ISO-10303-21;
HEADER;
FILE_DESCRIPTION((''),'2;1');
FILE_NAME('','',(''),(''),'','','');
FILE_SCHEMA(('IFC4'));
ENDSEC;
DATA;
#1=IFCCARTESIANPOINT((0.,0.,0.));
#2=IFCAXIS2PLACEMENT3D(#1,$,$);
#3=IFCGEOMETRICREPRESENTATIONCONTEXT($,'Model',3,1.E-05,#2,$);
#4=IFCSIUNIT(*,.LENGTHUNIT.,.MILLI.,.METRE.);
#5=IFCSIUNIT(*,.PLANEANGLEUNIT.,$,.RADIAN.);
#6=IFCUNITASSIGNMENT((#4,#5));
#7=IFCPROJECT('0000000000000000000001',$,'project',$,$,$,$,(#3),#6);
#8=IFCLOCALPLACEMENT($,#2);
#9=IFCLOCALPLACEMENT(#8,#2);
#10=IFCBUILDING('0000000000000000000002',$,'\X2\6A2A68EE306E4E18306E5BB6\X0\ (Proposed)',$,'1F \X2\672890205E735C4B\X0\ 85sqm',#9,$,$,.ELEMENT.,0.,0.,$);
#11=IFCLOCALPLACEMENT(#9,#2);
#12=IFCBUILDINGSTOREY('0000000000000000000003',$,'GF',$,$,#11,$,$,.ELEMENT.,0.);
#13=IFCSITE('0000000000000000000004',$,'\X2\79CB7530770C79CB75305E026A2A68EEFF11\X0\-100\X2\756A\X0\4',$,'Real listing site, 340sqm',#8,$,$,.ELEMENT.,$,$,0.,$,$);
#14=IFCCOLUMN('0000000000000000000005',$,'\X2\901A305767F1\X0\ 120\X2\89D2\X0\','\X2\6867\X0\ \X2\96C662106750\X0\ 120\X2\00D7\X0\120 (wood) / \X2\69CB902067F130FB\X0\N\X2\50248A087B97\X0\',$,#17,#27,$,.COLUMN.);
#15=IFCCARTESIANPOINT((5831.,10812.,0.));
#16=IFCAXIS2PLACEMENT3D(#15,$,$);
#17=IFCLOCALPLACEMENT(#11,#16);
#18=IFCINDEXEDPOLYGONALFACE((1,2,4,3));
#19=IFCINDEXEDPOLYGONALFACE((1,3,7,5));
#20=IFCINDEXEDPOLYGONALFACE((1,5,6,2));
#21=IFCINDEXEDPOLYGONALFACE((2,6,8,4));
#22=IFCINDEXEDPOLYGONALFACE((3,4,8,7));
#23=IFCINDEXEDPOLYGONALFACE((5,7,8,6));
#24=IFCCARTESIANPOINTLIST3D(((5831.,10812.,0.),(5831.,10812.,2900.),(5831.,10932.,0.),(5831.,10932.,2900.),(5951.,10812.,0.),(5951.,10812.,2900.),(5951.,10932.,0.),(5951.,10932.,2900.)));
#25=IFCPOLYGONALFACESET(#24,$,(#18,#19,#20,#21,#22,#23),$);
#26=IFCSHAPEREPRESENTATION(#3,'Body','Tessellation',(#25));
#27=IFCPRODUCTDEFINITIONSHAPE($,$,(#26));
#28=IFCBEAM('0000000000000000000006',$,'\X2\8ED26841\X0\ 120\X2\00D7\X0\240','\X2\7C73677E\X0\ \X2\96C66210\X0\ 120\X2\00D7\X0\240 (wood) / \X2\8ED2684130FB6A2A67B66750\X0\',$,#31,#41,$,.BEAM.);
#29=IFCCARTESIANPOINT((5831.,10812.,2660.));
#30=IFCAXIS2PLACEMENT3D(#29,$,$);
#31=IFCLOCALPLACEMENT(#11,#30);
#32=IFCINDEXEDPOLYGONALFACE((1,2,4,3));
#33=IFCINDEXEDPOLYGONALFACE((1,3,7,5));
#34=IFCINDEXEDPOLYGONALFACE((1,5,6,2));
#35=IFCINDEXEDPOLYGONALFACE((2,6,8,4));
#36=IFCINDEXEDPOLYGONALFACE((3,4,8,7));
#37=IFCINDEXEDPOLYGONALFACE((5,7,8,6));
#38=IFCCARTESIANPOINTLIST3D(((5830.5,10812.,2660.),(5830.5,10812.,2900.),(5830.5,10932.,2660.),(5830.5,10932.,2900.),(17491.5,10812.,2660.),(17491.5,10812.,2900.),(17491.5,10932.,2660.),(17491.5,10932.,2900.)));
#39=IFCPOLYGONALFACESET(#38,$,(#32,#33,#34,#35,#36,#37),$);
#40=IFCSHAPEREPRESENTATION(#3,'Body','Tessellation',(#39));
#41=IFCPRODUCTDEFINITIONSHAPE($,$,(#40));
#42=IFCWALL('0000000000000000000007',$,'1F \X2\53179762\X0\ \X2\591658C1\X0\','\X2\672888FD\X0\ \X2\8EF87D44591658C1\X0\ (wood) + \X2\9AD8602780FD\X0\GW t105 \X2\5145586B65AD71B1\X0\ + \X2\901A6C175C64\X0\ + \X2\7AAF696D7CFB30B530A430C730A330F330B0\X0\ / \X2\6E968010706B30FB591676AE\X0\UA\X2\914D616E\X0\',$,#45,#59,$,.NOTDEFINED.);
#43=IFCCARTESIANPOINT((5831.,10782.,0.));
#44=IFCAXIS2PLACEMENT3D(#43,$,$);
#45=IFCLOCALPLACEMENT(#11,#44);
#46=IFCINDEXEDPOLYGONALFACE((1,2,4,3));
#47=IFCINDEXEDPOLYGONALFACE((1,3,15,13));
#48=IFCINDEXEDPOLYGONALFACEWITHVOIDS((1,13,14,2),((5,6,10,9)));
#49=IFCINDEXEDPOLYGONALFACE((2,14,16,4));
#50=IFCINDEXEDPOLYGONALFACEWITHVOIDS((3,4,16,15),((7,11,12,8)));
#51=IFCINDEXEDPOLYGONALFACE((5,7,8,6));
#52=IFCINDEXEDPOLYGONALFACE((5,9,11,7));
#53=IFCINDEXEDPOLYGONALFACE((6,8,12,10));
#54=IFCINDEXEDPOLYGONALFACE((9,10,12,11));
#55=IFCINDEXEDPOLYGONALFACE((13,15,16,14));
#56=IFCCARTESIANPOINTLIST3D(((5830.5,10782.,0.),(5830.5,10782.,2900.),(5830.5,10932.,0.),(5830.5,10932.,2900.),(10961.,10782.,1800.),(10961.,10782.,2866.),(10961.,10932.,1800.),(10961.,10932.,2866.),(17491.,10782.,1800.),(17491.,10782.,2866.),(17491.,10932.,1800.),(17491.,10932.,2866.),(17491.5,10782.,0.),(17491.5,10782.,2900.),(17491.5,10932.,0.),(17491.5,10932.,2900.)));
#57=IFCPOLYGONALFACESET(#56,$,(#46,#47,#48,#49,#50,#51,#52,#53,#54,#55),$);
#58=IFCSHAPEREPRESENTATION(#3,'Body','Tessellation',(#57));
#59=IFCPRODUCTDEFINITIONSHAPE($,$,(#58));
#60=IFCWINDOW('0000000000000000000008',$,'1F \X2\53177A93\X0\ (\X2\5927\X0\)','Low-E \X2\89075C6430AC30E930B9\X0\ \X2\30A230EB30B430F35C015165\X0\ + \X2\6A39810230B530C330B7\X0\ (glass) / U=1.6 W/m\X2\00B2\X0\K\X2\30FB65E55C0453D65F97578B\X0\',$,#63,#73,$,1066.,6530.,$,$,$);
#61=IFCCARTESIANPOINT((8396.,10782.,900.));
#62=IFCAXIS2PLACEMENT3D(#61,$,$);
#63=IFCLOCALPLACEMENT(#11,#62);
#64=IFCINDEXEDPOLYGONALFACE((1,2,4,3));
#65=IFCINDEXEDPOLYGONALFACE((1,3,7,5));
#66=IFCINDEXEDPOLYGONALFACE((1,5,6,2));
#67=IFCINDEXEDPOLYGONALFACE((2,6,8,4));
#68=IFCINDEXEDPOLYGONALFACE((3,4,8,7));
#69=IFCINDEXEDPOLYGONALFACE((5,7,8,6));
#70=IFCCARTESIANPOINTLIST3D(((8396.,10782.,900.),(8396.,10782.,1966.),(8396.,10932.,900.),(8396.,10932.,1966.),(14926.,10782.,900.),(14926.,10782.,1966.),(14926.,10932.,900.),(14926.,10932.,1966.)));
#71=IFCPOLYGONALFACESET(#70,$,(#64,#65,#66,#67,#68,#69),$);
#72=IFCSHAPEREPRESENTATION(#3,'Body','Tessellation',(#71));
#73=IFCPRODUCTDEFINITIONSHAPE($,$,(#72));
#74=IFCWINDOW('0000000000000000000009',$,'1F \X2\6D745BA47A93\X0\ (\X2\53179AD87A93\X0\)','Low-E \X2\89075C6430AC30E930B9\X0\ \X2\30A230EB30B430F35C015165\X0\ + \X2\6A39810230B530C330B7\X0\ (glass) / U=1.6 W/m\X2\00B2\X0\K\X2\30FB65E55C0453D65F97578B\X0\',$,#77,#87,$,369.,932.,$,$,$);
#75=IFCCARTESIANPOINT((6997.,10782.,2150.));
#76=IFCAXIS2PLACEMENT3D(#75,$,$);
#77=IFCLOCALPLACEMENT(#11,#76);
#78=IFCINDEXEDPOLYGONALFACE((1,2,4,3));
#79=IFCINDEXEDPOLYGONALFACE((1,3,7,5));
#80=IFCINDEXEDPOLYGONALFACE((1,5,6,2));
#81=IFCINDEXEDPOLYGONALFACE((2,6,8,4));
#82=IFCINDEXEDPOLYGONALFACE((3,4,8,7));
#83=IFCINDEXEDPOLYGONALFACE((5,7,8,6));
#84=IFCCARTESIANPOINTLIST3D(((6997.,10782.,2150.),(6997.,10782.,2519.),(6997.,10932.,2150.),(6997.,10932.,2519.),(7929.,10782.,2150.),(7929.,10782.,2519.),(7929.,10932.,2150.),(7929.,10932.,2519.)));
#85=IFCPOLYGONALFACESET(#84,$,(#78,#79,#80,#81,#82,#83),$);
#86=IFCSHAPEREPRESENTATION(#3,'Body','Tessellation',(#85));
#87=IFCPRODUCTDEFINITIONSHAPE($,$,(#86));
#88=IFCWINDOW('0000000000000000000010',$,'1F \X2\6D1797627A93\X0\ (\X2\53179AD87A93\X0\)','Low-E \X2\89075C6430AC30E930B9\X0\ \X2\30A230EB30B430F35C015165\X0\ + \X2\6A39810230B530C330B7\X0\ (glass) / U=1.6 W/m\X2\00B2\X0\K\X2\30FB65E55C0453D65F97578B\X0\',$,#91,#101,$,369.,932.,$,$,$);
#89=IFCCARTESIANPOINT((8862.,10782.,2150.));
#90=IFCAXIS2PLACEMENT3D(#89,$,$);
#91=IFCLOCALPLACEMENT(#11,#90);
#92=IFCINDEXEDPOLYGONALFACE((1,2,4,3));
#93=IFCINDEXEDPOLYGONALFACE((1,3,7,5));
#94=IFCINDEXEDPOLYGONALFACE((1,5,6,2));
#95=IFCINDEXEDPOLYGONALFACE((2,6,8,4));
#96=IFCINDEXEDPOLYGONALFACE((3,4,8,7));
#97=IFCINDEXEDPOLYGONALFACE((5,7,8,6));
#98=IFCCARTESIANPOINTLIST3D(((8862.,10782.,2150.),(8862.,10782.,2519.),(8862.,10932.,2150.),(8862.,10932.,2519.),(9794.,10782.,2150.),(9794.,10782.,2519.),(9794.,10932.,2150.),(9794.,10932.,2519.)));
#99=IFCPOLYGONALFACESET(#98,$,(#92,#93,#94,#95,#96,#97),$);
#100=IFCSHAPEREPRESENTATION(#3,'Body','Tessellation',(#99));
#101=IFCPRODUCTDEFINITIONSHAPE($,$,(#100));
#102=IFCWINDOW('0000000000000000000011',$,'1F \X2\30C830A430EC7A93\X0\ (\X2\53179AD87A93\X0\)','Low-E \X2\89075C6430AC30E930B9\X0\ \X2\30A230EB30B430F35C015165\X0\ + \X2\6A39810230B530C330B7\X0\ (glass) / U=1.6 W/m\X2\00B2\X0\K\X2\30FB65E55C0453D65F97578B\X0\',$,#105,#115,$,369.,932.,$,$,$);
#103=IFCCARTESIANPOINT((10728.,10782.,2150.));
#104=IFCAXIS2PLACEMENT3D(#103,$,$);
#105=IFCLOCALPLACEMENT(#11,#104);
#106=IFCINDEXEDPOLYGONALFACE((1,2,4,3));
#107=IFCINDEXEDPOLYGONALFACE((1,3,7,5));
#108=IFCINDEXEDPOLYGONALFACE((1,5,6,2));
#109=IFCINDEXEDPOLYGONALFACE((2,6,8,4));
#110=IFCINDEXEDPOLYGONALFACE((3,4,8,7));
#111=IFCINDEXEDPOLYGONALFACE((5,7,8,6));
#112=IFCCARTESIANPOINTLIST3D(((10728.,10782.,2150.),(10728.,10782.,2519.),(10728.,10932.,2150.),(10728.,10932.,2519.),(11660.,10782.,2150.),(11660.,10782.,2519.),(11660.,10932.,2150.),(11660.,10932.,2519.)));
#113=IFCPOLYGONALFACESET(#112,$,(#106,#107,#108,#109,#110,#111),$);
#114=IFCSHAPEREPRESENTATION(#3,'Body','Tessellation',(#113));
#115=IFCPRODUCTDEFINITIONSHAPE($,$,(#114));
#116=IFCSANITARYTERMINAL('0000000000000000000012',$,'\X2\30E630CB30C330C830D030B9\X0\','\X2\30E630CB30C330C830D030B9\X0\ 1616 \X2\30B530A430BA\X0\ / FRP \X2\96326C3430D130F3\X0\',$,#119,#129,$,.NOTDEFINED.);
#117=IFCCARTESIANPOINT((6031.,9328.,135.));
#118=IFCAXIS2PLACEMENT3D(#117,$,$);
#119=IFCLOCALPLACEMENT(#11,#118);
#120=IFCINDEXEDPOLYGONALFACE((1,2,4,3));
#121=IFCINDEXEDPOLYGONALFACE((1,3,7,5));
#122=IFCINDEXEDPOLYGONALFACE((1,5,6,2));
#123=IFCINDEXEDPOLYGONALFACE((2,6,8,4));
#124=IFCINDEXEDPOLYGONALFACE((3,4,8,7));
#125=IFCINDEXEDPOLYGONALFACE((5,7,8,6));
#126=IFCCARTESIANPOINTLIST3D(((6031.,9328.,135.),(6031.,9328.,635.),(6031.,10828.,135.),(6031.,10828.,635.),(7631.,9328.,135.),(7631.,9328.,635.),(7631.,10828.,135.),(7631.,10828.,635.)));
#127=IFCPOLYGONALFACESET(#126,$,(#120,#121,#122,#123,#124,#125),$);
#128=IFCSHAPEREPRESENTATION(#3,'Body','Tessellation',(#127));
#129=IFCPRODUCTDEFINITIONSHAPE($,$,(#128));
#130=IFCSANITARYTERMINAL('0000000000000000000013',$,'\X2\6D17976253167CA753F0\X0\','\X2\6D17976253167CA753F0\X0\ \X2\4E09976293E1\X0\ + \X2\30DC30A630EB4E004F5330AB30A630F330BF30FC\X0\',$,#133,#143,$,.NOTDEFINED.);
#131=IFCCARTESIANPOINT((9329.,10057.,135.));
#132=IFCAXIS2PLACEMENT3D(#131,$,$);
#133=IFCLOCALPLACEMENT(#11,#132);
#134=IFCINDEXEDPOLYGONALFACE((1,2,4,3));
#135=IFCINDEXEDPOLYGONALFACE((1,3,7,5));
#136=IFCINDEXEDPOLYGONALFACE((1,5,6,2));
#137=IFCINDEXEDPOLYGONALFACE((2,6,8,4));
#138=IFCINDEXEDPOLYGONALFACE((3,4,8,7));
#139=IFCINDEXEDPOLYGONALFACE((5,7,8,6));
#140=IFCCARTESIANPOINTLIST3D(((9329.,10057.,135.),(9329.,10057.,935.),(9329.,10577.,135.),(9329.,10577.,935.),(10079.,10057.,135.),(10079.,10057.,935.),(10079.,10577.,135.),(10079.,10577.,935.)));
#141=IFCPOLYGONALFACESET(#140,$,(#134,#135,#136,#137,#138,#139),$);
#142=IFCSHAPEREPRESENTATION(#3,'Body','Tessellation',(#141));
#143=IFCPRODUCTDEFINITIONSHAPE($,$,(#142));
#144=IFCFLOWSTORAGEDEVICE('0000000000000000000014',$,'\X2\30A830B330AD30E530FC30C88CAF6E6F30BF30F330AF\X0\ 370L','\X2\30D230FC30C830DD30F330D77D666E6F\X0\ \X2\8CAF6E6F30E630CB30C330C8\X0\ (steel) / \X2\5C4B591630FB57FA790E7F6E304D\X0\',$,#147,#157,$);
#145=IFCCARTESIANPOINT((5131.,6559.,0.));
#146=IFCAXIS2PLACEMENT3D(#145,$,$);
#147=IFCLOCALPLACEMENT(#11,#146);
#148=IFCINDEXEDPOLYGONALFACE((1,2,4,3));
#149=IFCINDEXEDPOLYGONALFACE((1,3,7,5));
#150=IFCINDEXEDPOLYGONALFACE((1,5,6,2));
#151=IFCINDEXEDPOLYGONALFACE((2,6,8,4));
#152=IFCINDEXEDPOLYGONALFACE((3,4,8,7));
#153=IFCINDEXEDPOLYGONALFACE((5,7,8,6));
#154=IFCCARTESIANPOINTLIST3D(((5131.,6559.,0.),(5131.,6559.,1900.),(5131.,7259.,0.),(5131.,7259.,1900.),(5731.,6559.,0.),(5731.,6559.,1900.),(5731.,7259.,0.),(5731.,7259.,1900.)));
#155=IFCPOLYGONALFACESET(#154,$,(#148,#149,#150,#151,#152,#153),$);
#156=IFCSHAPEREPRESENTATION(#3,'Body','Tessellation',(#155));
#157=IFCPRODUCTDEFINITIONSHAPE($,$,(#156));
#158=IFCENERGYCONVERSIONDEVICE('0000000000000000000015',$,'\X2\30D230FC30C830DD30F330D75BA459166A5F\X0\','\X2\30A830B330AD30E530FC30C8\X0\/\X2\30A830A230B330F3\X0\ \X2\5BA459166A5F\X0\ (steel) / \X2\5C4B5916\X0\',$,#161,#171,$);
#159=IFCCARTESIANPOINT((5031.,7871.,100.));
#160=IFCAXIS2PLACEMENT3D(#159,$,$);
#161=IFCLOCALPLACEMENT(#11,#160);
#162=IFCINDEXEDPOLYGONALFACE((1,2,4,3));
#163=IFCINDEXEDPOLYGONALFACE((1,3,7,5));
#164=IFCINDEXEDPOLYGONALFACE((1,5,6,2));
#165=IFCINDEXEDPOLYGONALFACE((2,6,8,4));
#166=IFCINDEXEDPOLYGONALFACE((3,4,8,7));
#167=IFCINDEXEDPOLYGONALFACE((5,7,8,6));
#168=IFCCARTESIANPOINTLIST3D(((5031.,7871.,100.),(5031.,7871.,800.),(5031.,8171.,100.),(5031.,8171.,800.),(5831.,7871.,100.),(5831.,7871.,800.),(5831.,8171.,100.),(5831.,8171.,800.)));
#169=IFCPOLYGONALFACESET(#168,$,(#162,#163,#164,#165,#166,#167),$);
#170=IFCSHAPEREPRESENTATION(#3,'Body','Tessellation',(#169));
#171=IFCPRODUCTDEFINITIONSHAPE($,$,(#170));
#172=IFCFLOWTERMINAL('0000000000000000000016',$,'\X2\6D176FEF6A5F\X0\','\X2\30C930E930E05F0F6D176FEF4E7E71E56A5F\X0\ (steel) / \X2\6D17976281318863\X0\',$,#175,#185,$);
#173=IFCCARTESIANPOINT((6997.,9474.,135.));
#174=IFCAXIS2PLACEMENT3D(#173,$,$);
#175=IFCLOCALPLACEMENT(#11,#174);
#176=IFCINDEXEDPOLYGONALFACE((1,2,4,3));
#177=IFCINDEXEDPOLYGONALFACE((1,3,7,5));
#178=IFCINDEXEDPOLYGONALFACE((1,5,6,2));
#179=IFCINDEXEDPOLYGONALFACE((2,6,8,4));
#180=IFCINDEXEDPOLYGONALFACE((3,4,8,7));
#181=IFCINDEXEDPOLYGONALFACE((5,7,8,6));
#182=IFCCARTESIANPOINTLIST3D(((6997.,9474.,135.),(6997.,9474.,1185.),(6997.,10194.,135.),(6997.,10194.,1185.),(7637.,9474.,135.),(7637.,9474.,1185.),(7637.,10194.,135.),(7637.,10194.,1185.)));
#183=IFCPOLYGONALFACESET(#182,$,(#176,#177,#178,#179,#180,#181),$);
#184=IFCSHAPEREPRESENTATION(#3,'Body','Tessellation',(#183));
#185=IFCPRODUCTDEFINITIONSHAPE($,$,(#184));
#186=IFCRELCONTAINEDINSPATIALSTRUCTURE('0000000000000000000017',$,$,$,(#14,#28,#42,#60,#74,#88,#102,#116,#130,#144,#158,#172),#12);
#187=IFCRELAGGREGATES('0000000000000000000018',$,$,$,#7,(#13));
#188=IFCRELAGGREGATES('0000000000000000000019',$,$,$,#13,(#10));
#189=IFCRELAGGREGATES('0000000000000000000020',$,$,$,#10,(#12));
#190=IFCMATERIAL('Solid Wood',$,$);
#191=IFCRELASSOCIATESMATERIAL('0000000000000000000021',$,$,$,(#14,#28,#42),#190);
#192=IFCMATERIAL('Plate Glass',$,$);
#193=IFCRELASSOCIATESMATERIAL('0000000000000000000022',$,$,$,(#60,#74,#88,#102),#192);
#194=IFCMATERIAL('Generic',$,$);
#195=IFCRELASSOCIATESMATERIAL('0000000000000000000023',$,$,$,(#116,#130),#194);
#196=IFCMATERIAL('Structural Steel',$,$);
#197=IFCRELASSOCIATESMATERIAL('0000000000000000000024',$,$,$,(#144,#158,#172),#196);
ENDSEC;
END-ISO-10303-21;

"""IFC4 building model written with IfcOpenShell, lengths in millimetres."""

from ifc_helpers import new_model, si_unit, frame, frame_2d, origin, place, context, project, spatial, rectangle, extrude, material, element, fill, save


model = new_model("IFC4")

# Units and contexts
model_context = context("Model", 3, precision=1e-05, world=origin())
ifc_project = project(units=[si_unit("LENGTHUNIT", "METRE", prefix="MILLI"), si_unit("PLANEANGLEUNIT", "RADIAN")], contexts=[model_context])

# Site, building, storey
site_placement = place(None, origin())
site = spatial("IfcSite", under=ifc_project, at=site_placement, Name="秋田県秋田市横森１-100番4", ObjectType="Real listing site, 340sqm", CompositionType="ELEMENT", RefElevation=0.0)
building_placement = place(site_placement, origin())
building = spatial("IfcBuilding", under=site, at=building_placement, Name="横森の丘の家 (Proposed)", ObjectType="1F 木造平屋 85sqm", CompositionType="ELEMENT", ElevationOfRefHeight=0.0, ElevationOfTerrain=0.0)
storey_placement = place(building_placement, origin())
storey = spatial("IfcBuildingStorey", under=building, at=storey_placement, Name="GF", CompositionType="ELEMENT", Elevation=0.0)

# Column
ifc_material_1 = material(Name="Solid Wood")
column_1_placement = place(storey_placement, frame((5831.0, 10812.0, 0.0)))
element("IfcColumn", 1, at=column_1_placement, inside=storey, material=ifc_material_1, Name="通し柱 120角", Description="桧 集成材 120×120 (wood) / 構造柱・N値計算", PredefinedType="COLUMN", context=model_context, shape_type="SweptSolid", body=[
    extrude(rectangle(XDim=120.0, YDim=120.0, at=frame_2d((60.0, 60.0))), frame((5831.0, 10812.0, 0.0)), (0.0, 0.0, 1.0), 2900.0),
])

# Beam
beam_1_placement = place(storey_placement, frame((5831.0, 10812.0, 2660.0)))
element("IfcBeam", 2, at=beam_1_placement, inside=storey, material=ifc_material_1, Name="軒桁 120×240", Description="米松 集成 120×240 (wood) / 軒桁・横架材", PredefinedType="BEAM", context=model_context, shape_type="SweptSolid", body=[
    extrude(rectangle(XDim=11661.0, YDim=120.0, at=frame_2d((5830.0, 60.0))), frame((5831.0, 10812.0, 2660.0)), (0.0, 0.0, 1.0), 240.0),
])

# Wall, openings, windows
wall_1_placement = place(storey_placement, frame((5831.0, 10782.0, 0.0)))
wall_1 = element("IfcWall", 3, at=wall_1_placement, inside=storey, material=ifc_material_1, Name="1F 北面 外壁", Description="木製 軸組外壁 (wood) + 高性能GW t105 充填断熱 + 通気層 + 窯業系サイディング / 準耐火・外皮UA配慮", PredefinedType="NOTDEFINED", context=model_context, shape_type="SweptSolid", body=[
    extrude(rectangle(XDim=11661.0, YDim=150.0, at=frame_2d((5830.0, 75.0))), frame((5831.0, 10782.0, 0.0)), (0.0, 0.0, 1.0), 2900.0),
])
opening_1_placement = place(storey_placement, frame((8396.0, 10782.0, 900.0)))
opening_1 = element("IfcOpeningElement", 4, at=opening_1_placement, cuts=wall_1, PredefinedType="NOTDEFINED", context=model_context, shape_type="SweptSolid", body=[
    extrude(rectangle(XDim=6530.0, YDim=150.0, at=frame_2d((3265.0, 75.0))), frame((8396.0, 10782.0, 900.0)), (0.0, 0.0, 1.0), 1066.0),
])
opening_2_placement = place(storey_placement, frame((6997.0, 10782.0, 2150.0)))
opening_2 = element("IfcOpeningElement", 5, at=opening_2_placement, cuts=wall_1, PredefinedType="NOTDEFINED", context=model_context, shape_type="SweptSolid", body=[
    extrude(rectangle(XDim=932.0, YDim=150.0, at=frame_2d((466.0, 75.0))), frame((6997.0, 10782.0, 2150.0)), (0.0, 0.0, 1.0), 369.0),
])
opening_3_placement = place(storey_placement, frame((8862.0, 10782.0, 2150.0)))
opening_3 = element("IfcOpeningElement", 6, at=opening_3_placement, cuts=wall_1, PredefinedType="NOTDEFINED", context=model_context, shape_type="SweptSolid", body=[
    extrude(rectangle(XDim=932.0, YDim=150.0, at=frame_2d((466.0, 75.0))), frame((8862.0, 10782.0, 2150.0)), (0.0, 0.0, 1.0), 369.0),
])
opening_4_placement = place(storey_placement, frame((10728.0, 10782.0, 2150.0)))
opening_4 = element("IfcOpeningElement", 7, at=opening_4_placement, cuts=wall_1, PredefinedType="NOTDEFINED", context=model_context, shape_type="SweptSolid", body=[
    extrude(rectangle(XDim=932.0, YDim=150.0, at=frame_2d((466.0, 75.0))), frame((10728.0, 10782.0, 2150.0)), (0.0, 0.0, 1.0), 369.0),
])
ifc_material_2 = material(Name="Plate Glass")
window_1_placement = place(storey_placement, frame((8396.0, 10782.0, 900.0)))
window_1 = element("IfcWindow", 8, at=window_1_placement, inside=storey, material=ifc_material_2, Name="1F 北窓 (大)", Description="Low-E 複層ガラス アルゴン封入 + 樹脂サッシ (glass) / U=1.6 W/m²K・日射取得型", OverallHeight=1066.0, OverallWidth=6530.0, context=model_context, shape_type="SweptSolid", body=[
    extrude(rectangle(XDim=6530.0, YDim=150.0, at=frame_2d((3265.0, 75.0))), frame((8396.0, 10782.0, 900.0)), (0.0, 0.0, 1.0), 1066.0),
])
fill(opening_1, window_1)
window_2_placement = place(storey_placement, frame((6997.0, 10782.0, 2150.0)))
window_2 = element("IfcWindow", 9, at=window_2_placement, inside=storey, material=ifc_material_2, Name="1F 浴室窓 (北高窓)", Description="Low-E 複層ガラス アルゴン封入 + 樹脂サッシ (glass) / U=1.6 W/m²K・日射取得型", OverallHeight=369.0, OverallWidth=932.0, context=model_context, shape_type="SweptSolid", body=[
    extrude(rectangle(XDim=932.0, YDim=150.0, at=frame_2d((466.0, 75.0))), frame((6997.0, 10782.0, 2150.0)), (0.0, 0.0, 1.0), 369.0),
])
fill(opening_2, window_2)
window_3_placement = place(storey_placement, frame((8862.0, 10782.0, 2150.0)))
window_3 = element("IfcWindow", 10, at=window_3_placement, inside=storey, material=ifc_material_2, Name="1F 洗面窓 (北高窓)", Description="Low-E 複層ガラス アルゴン封入 + 樹脂サッシ (glass) / U=1.6 W/m²K・日射取得型", OverallHeight=369.0, OverallWidth=932.0, context=model_context, shape_type="SweptSolid", body=[
    extrude(rectangle(XDim=932.0, YDim=150.0, at=frame_2d((466.0, 75.0))), frame((8862.0, 10782.0, 2150.0)), (0.0, 0.0, 1.0), 369.0),
])
fill(opening_3, window_3)
window_4_placement = place(storey_placement, frame((10728.0, 10782.0, 2150.0)))
window_4 = element("IfcWindow", 11, at=window_4_placement, inside=storey, material=ifc_material_2, Name="1F トイレ窓 (北高窓)", Description="Low-E 複層ガラス アルゴン封入 + 樹脂サッシ (glass) / U=1.6 W/m²K・日射取得型", OverallHeight=369.0, OverallWidth=932.0, context=model_context, shape_type="SweptSolid", body=[
    extrude(rectangle(XDim=932.0, YDim=150.0, at=frame_2d((466.0, 75.0))), frame((10728.0, 10782.0, 2150.0)), (0.0, 0.0, 1.0), 369.0),
])
fill(opening_4, window_4)

# Sanitary terminals
ifc_material_3 = material(Name="Generic")
sanitary_terminal_1_placement = place(storey_placement, frame((6031.0, 9328.0, 135.0)))
element("IfcSanitaryTerminal", 12, at=sanitary_terminal_1_placement, inside=storey, material=ifc_material_3, Name="ユニットバス", Description="ユニットバス 1616 サイズ / FRP 防水パン", PredefinedType="NOTDEFINED", context=model_context, shape_type="SweptSolid", body=[
    extrude(rectangle(XDim=1600.0, YDim=1500.0, at=frame_2d((800.0, 750.0))), frame((6031.0, 9328.0, 135.0)), (0.0, 0.0, 1.0), 500.0),
])
sanitary_terminal_2_placement = place(storey_placement, frame((9329.0, 10057.0, 135.0)))
element("IfcSanitaryTerminal", 13, at=sanitary_terminal_2_placement, inside=storey, material=ifc_material_3, Name="洗面化粧台", Description="洗面化粧台 三面鏡 + ボウル一体カウンター", PredefinedType="NOTDEFINED", context=model_context, shape_type="SweptSolid", body=[
    extrude(rectangle(XDim=750.0, YDim=520.0, at=frame_2d((375.0, 260.0))), frame((9329.0, 10057.0, 135.0)), (0.0, 0.0, 1.0), 800.0),
])

# Flow storage device
ifc_material_4 = material(Name="Structural Steel")
flow_storage_device_placement = place(storey_placement, frame((5131.0, 6559.0, 0.0)))
element("IfcFlowStorageDevice", 14, at=flow_storage_device_placement, inside=storey, material=ifc_material_4, Name="エコキュート貯湯タンク 370L", Description="ヒートポンプ給湯 貯湯ユニット (steel) / 屋外・基礎置き", context=model_context, shape_type="SweptSolid", body=[
    extrude(rectangle(XDim=600.0, YDim=700.0, at=frame_2d((300.0, 350.0))), frame((5131.0, 6559.0, 0.0)), (0.0, 0.0, 1.0), 1900.0),
])

# Energy conversion device
energy_conversion_device_placement = place(storey_placement, frame((5031.0, 7871.0, 100.0)))
element("IfcEnergyConversionDevice", 15, at=energy_conversion_device_placement, inside=storey, material=ifc_material_4, Name="ヒートポンプ室外機", Description="エコキュート/エアコン 室外機 (steel) / 屋外", context=model_context, shape_type="SweptSolid", body=[
    extrude(rectangle(XDim=800.0, YDim=300.0, at=frame_2d((400.0, 150.0))), frame((5031.0, 7871.0, 100.0)), (0.0, 0.0, 1.0), 700.0),
])

# Flow terminal
flow_terminal_placement = place(storey_placement, frame((6997.0, 9474.0, 135.0)))
element("IfcFlowTerminal", 16, at=flow_terminal_placement, inside=storey, material=ifc_material_4, Name="洗濯機", Description="ドラム式洗濯乾燥機 (steel) / 洗面脱衣", context=model_context, shape_type="SweptSolid", body=[
    extrude(rectangle(XDim=640.0, YDim=720.0, at=frame_2d((320.0, 360.0))), frame((6997.0, 9474.0, 135.0)), (0.0, 0.0, 1.0), 1050.0),
])

save(model, "model.ifc")
